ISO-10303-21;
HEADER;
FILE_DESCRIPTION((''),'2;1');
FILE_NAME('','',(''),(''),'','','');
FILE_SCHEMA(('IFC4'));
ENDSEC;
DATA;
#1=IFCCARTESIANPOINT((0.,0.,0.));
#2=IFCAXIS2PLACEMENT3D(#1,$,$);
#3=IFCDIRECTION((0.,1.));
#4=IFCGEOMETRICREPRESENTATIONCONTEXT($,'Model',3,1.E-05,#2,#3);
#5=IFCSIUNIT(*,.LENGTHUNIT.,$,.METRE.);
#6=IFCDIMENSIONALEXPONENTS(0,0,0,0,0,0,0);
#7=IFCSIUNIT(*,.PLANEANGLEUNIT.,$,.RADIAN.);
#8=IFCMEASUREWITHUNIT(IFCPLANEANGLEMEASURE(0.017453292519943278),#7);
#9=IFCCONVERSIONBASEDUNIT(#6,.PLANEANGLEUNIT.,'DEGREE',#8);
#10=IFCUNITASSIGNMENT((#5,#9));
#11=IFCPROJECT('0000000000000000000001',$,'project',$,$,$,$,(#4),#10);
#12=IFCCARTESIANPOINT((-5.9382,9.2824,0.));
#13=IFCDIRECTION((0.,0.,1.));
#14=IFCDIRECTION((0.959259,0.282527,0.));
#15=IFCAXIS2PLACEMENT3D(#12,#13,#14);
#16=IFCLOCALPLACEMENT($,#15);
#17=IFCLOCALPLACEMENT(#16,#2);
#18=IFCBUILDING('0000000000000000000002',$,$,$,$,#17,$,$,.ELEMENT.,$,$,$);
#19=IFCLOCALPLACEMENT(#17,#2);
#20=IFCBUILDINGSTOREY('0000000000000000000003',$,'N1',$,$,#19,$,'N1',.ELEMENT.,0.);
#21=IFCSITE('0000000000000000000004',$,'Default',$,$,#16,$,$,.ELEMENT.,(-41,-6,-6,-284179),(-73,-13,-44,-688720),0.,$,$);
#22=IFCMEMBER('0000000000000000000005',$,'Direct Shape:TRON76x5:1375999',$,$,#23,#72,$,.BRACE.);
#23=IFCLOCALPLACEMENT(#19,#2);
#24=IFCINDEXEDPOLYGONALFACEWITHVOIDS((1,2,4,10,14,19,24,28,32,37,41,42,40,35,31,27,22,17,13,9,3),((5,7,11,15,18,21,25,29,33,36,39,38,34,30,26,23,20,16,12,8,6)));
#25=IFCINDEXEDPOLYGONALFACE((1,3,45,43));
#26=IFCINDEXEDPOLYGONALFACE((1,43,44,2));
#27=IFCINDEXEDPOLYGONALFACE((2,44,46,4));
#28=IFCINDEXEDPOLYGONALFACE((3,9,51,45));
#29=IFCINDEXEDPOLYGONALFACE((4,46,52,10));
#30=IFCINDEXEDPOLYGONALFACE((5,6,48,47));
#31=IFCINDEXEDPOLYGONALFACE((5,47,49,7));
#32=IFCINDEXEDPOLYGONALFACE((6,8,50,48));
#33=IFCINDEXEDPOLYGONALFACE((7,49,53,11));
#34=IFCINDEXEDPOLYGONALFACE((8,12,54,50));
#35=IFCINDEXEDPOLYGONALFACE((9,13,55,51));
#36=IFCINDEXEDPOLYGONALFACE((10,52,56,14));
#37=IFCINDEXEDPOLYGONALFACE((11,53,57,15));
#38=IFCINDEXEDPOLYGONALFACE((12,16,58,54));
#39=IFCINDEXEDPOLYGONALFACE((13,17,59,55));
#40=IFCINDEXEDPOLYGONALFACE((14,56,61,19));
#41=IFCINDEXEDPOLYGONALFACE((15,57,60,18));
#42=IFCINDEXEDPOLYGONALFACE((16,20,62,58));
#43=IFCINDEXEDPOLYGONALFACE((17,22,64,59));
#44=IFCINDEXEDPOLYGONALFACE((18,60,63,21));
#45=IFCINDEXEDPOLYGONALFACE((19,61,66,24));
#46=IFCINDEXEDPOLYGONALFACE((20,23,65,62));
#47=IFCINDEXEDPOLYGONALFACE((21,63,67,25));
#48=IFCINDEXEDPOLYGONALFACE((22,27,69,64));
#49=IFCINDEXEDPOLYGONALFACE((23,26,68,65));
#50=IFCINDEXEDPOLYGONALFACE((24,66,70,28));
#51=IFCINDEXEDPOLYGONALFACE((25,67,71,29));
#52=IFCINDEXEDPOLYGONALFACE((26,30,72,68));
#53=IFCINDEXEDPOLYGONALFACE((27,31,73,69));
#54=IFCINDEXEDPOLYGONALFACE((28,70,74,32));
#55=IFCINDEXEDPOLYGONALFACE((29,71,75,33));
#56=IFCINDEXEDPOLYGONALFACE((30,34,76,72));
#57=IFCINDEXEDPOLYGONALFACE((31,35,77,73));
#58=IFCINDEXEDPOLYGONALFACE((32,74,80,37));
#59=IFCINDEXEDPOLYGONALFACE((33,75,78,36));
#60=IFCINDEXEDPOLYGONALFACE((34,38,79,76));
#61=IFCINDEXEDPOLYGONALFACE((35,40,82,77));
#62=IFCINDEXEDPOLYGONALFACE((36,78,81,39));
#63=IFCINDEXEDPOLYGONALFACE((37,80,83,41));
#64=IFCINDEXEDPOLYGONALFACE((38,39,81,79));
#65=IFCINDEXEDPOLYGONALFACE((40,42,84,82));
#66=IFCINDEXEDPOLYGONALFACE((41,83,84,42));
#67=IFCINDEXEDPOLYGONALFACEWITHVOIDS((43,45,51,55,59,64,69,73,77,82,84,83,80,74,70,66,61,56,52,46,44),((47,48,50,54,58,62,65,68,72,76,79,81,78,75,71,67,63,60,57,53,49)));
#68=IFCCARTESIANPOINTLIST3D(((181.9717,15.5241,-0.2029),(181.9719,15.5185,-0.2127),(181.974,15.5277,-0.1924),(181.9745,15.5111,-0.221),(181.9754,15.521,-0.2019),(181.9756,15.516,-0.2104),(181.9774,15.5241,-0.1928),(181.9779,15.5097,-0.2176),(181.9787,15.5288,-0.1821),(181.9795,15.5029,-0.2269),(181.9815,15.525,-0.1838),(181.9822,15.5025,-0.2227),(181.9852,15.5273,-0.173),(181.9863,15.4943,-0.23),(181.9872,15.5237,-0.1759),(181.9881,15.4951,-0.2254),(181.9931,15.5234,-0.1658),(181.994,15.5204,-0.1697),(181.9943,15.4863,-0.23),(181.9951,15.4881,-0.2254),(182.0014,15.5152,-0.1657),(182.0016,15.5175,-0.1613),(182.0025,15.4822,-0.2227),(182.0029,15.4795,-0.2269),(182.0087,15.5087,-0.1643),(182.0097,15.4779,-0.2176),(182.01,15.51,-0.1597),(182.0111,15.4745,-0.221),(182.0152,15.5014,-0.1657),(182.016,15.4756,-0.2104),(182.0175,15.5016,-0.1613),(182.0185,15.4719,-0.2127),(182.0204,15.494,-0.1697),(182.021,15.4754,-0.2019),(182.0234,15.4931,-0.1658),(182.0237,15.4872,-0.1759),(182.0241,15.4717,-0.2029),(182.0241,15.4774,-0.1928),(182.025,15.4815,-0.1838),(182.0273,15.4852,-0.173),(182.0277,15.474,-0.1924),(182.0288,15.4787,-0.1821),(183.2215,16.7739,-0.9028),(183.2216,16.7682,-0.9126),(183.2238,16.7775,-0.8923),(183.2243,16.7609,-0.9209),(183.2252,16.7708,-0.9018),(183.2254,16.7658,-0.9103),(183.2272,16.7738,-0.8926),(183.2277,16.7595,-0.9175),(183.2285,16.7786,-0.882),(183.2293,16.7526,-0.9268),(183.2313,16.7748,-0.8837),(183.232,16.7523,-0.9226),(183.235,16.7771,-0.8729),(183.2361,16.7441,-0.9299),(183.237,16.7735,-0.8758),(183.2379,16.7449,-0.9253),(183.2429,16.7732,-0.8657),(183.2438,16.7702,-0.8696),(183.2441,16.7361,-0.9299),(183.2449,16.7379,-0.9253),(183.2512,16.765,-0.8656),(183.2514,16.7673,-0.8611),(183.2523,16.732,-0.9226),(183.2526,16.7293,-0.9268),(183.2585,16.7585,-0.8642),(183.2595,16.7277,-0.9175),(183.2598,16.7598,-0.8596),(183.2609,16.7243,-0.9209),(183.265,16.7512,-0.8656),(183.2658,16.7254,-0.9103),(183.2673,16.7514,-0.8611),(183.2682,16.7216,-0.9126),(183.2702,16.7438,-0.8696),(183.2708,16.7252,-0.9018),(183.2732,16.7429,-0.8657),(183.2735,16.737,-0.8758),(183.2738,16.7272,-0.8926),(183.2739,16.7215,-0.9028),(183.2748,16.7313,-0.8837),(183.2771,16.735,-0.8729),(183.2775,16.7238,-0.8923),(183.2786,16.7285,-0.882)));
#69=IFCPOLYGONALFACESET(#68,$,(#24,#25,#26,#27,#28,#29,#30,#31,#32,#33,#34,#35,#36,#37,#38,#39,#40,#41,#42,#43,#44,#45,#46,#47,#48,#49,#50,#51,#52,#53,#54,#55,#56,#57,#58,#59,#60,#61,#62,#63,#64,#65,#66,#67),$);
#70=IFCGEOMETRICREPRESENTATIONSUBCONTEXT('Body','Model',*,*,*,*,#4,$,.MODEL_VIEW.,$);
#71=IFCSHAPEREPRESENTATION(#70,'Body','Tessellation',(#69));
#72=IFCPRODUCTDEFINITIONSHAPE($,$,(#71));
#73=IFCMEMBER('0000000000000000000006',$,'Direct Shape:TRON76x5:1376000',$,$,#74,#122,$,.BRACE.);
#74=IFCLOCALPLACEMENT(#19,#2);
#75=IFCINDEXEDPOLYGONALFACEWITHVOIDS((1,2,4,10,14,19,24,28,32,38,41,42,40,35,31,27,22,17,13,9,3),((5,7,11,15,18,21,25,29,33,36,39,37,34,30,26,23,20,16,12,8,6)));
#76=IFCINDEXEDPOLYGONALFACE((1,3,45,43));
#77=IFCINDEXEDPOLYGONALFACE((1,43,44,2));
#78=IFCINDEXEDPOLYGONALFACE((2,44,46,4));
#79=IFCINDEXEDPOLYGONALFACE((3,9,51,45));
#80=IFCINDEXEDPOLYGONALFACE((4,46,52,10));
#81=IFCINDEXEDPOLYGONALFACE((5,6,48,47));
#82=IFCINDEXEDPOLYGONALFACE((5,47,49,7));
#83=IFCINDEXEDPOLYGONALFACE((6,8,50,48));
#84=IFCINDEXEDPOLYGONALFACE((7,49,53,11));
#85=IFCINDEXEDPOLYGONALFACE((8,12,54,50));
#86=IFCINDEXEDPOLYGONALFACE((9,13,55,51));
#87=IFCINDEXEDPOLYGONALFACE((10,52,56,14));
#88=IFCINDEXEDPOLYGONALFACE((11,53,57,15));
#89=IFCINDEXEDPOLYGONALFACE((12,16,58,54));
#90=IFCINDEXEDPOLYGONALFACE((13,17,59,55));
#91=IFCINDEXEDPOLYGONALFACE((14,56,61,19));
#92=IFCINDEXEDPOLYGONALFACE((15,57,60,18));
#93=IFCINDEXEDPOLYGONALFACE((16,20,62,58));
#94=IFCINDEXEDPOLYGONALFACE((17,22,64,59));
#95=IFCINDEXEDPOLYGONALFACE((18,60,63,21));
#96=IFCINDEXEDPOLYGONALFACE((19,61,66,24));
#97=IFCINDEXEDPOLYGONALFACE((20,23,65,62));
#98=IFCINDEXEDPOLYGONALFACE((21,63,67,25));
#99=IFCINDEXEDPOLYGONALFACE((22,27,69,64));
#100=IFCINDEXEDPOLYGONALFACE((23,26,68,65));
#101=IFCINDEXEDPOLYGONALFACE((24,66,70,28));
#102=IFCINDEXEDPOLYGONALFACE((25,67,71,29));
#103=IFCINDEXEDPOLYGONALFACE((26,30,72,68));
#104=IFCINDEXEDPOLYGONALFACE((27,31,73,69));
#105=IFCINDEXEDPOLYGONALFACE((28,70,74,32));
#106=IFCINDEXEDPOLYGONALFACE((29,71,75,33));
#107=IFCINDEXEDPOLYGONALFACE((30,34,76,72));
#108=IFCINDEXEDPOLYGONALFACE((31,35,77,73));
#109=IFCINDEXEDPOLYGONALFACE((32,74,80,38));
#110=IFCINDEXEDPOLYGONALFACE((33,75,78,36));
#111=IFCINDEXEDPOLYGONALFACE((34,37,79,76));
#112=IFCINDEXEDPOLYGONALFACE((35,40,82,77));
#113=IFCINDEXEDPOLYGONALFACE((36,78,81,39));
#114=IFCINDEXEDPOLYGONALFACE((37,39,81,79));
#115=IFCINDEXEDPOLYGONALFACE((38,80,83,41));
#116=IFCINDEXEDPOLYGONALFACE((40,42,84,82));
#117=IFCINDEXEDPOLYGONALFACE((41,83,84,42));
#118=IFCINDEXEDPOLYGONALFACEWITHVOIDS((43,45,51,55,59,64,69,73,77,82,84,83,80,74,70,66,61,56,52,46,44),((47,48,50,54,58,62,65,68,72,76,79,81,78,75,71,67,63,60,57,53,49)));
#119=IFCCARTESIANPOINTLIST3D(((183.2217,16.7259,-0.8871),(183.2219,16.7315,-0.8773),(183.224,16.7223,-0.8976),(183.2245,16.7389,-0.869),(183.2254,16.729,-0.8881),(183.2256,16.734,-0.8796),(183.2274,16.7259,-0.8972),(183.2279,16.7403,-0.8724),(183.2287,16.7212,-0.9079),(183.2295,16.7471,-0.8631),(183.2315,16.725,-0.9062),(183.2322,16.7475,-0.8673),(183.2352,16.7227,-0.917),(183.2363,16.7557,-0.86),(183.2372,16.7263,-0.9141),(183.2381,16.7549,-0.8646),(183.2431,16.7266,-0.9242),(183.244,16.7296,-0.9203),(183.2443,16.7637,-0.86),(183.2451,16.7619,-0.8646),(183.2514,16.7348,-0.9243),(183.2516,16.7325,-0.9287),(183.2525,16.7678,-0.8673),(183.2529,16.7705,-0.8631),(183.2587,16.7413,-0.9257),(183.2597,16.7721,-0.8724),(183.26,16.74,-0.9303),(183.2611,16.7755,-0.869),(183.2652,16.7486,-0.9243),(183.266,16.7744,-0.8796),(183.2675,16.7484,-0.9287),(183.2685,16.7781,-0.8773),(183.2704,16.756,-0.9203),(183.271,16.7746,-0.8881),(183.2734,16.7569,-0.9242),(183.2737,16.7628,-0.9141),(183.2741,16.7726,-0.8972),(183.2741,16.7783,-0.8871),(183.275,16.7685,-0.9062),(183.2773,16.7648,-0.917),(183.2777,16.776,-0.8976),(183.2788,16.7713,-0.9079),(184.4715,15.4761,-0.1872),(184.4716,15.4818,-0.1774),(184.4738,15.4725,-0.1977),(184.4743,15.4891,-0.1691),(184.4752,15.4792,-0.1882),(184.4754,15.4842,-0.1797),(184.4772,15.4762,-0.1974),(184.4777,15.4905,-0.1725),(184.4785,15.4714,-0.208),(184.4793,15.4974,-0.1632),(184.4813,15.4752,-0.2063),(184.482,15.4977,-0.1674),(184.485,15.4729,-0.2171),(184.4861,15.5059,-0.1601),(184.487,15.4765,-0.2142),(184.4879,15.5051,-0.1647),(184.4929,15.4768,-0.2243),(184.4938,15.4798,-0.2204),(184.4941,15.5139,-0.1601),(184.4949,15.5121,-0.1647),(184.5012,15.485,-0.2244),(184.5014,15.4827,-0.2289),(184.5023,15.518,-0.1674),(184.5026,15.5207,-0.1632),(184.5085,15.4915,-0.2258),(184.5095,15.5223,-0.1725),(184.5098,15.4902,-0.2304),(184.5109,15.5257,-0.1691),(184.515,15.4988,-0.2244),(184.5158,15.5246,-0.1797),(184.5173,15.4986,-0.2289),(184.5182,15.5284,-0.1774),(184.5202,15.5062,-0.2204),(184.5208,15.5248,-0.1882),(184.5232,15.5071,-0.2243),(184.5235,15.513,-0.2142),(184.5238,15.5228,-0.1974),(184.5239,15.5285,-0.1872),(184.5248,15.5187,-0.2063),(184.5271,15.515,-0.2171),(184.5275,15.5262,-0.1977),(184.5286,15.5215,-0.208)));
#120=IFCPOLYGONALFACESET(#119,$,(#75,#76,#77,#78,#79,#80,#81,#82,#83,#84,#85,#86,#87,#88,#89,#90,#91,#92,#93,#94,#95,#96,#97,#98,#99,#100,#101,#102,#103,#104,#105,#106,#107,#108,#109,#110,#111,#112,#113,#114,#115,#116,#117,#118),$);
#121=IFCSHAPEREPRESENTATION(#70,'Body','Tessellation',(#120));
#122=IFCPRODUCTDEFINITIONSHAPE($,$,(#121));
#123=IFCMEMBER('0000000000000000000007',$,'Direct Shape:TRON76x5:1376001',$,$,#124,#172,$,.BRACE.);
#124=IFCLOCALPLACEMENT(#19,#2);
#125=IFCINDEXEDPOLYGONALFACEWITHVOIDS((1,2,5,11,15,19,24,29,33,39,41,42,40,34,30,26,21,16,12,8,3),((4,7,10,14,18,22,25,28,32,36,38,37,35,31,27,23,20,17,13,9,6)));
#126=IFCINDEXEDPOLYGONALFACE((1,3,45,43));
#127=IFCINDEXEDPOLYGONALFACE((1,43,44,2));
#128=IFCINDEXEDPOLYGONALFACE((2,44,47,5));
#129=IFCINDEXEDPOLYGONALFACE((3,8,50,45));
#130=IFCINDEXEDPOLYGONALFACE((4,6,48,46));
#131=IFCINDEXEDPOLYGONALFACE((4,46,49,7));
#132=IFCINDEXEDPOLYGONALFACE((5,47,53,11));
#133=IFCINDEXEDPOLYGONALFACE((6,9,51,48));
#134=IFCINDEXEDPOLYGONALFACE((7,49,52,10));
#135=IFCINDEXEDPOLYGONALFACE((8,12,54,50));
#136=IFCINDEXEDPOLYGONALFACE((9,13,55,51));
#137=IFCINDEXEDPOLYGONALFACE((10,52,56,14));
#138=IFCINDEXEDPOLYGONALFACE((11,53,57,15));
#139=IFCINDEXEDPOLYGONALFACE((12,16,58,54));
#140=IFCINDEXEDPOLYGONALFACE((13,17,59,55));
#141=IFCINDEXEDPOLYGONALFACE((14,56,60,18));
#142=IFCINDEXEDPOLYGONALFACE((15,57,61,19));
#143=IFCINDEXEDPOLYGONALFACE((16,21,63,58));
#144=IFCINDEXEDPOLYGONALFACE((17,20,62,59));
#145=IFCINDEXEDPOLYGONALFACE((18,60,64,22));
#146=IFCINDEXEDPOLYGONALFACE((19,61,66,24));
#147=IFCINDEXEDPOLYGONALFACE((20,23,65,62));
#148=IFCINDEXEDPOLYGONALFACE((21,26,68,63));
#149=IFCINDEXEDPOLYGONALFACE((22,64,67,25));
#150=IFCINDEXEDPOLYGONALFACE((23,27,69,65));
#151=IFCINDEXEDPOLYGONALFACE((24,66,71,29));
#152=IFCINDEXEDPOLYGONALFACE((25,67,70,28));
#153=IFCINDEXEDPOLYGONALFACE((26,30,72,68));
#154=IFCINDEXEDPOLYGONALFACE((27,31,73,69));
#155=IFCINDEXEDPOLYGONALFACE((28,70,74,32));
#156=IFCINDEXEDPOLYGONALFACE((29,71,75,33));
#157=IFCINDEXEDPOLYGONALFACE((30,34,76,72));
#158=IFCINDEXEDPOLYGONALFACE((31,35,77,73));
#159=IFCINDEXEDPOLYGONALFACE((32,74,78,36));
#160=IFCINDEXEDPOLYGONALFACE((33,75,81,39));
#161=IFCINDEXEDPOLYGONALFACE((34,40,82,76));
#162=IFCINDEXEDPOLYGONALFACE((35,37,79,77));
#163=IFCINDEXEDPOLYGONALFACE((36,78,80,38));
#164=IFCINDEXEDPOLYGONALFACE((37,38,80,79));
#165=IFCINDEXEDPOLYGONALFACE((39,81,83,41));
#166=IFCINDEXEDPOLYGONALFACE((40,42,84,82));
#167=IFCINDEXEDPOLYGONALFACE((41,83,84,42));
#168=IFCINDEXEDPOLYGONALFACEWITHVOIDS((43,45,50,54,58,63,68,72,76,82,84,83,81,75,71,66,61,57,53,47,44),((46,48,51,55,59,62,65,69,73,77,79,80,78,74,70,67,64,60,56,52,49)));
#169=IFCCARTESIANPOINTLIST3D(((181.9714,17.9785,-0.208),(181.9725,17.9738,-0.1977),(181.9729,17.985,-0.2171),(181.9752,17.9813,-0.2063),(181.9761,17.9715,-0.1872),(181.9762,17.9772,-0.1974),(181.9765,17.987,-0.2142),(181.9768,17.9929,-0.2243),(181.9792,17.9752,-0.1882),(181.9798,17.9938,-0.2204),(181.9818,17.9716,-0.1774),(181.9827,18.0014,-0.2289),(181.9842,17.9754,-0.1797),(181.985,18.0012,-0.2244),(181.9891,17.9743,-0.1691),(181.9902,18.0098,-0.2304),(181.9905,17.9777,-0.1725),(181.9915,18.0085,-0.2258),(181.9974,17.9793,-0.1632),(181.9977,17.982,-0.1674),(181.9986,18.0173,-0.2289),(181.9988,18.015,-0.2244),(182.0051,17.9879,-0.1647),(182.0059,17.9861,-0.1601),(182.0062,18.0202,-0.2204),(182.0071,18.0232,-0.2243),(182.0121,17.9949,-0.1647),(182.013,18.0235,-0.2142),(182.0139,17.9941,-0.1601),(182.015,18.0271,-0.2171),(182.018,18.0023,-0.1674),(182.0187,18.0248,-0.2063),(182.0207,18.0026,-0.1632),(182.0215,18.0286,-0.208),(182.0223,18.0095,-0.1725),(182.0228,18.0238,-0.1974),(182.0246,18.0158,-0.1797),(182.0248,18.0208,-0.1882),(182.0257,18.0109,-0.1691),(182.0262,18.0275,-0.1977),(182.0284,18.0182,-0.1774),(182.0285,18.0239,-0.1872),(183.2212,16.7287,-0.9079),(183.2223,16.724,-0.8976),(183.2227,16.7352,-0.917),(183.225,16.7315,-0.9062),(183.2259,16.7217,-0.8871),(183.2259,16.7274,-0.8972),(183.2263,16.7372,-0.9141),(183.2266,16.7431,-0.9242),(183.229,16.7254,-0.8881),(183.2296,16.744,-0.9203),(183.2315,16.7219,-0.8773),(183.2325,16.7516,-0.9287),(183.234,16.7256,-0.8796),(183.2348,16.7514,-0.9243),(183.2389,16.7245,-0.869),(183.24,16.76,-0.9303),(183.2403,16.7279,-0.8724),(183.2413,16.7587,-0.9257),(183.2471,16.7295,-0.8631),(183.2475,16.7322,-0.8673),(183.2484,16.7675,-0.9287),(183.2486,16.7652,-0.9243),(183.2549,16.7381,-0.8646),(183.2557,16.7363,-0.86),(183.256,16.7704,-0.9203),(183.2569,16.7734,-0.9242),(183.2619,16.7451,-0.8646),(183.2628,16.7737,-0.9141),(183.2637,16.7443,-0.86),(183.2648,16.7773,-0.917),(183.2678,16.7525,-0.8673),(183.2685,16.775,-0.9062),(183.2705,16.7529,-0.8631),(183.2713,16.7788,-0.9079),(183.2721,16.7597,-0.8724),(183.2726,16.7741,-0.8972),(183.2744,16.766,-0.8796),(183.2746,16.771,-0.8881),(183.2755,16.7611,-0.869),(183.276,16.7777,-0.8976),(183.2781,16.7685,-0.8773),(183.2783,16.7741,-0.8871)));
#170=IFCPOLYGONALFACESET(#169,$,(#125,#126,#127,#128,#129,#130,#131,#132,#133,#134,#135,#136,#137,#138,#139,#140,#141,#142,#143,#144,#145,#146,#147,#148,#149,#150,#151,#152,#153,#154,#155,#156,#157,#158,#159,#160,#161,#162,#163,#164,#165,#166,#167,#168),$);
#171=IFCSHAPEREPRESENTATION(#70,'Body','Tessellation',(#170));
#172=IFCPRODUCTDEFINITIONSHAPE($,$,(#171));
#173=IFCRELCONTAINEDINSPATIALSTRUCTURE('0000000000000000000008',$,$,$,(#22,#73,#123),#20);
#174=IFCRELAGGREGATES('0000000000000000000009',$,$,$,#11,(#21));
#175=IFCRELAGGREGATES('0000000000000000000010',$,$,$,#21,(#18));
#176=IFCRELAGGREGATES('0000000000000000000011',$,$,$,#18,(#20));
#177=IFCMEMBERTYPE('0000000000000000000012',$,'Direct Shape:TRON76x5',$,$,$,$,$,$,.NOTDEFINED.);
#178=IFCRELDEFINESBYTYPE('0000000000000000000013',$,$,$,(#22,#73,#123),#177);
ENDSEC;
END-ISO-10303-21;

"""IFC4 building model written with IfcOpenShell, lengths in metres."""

from ifc_helpers import new_model, entity, si_unit, converted_unit, direction, frame, frame_2d, origin, origin_2d_with_axis, place, context, subcontext, project, spatial, hollow_circle, extrude, type_object, element, save


model = new_model("IFC4")

# Units and contexts
model_context = context("Model", 3, precision=1e-05, world=origin(), true_north=direction((0.0, 1.0)))
body_context = subcontext(model_context, "Body", "Model", "MODEL_VIEW")
ifc_project = project(units=[si_unit("LENGTHUNIT", "METRE"), converted_unit("PLANEANGLEUNIT", "DEGREE", entity("IfcPlaneAngleMeasure", 0.017453292519943278), si_unit("PLANEANGLEUNIT", "RADIAN"), dimensions=[0, 0, 0, 0, 0, 0, 0])], contexts=[model_context])

# Site, building, storey
site_placement = place(None, frame((-5.9382, 9.2824, 0.0), z_axis=(0.0, 0.0, 1.0), x_axis=(0.959259, 0.282527, 0.0)))
site = spatial("IfcSite", under=ifc_project, at=site_placement, Name="Default", CompositionType="ELEMENT", RefLatitude=(-41, -6, -6, -284179), RefLongitude=(-73, -13, -44, -688720), RefElevation=0.0)
building_placement = place(site_placement, origin())
building = spatial("IfcBuilding", under=site, at=building_placement, CompositionType="ELEMENT")
storey_placement = place(building_placement, origin())
storey = spatial("IfcBuildingStorey", under=building, at=storey_placement, Name="N1", LongName="N1", CompositionType="ELEMENT", Elevation=0.0)

# Members
member_type_1 = type_object("IfcMemberType", Name="Direct Shape:TRON76x5", PredefinedType="NOTDEFINED")
member_1_placement = place(storey_placement, origin())
element("IfcMember", 1, at=member_1_placement, inside=storey, type_object=member_type_1, Name="Direct Shape:TRON76x5:1375999", PredefinedType="BRACE", context=body_context, shape_type="SweptSolid", body=[
    extrude(hollow_circle(Radius=0.0381, WallThickness=0.005, at=frame_2d((0.0, 0.0), x_axis=(1.0, 0.0))), frame((182.0001, 15.5001, -0.1951), z_axis=(0.65744, 0.65744, -0.368166), x_axis=(0.260333, 0.260333, 0.92976)), (0.0, 0.0, 1.0), 1.901),
])
member_2_placement = place(storey_placement, origin())
element("IfcMember", 2, at=member_2_placement, inside=storey, type_object=member_type_1, Name="Direct Shape:TRON76x5:1376000", PredefinedType="BRACE", context=body_context, shape_type="SweptSolid", body=[
    extrude(hollow_circle(Radius=0.0381, WallThickness=0.005, at=origin_2d_with_axis()), frame((183.2501, 16.7499, -0.8949), z_axis=(0.65744, -0.65744, 0.368166), x_axis=(0.260333, -0.260333, -0.92976)), (0.0, 0.0, 1.0), 1.901),
])
member_3_placement = place(storey_placement, origin())
element("IfcMember", 3, at=member_3_placement, inside=storey, type_object=member_type_1, Name="Direct Shape:TRON76x5:1376001", PredefinedType="BRACE", context=body_context, shape_type="SweptSolid", body=[
    extrude(hollow_circle(Radius=0.0381, WallThickness=0.005, at=origin_2d_with_axis()), frame((183.2499, 16.7501, -0.8949), z_axis=(-0.65744, 0.65744, 0.368166), x_axis=(-0.260333, 0.260333, -0.92976)), (0.0, 0.0, 1.0), 1.901),
])

save(model, "model.ifc")
